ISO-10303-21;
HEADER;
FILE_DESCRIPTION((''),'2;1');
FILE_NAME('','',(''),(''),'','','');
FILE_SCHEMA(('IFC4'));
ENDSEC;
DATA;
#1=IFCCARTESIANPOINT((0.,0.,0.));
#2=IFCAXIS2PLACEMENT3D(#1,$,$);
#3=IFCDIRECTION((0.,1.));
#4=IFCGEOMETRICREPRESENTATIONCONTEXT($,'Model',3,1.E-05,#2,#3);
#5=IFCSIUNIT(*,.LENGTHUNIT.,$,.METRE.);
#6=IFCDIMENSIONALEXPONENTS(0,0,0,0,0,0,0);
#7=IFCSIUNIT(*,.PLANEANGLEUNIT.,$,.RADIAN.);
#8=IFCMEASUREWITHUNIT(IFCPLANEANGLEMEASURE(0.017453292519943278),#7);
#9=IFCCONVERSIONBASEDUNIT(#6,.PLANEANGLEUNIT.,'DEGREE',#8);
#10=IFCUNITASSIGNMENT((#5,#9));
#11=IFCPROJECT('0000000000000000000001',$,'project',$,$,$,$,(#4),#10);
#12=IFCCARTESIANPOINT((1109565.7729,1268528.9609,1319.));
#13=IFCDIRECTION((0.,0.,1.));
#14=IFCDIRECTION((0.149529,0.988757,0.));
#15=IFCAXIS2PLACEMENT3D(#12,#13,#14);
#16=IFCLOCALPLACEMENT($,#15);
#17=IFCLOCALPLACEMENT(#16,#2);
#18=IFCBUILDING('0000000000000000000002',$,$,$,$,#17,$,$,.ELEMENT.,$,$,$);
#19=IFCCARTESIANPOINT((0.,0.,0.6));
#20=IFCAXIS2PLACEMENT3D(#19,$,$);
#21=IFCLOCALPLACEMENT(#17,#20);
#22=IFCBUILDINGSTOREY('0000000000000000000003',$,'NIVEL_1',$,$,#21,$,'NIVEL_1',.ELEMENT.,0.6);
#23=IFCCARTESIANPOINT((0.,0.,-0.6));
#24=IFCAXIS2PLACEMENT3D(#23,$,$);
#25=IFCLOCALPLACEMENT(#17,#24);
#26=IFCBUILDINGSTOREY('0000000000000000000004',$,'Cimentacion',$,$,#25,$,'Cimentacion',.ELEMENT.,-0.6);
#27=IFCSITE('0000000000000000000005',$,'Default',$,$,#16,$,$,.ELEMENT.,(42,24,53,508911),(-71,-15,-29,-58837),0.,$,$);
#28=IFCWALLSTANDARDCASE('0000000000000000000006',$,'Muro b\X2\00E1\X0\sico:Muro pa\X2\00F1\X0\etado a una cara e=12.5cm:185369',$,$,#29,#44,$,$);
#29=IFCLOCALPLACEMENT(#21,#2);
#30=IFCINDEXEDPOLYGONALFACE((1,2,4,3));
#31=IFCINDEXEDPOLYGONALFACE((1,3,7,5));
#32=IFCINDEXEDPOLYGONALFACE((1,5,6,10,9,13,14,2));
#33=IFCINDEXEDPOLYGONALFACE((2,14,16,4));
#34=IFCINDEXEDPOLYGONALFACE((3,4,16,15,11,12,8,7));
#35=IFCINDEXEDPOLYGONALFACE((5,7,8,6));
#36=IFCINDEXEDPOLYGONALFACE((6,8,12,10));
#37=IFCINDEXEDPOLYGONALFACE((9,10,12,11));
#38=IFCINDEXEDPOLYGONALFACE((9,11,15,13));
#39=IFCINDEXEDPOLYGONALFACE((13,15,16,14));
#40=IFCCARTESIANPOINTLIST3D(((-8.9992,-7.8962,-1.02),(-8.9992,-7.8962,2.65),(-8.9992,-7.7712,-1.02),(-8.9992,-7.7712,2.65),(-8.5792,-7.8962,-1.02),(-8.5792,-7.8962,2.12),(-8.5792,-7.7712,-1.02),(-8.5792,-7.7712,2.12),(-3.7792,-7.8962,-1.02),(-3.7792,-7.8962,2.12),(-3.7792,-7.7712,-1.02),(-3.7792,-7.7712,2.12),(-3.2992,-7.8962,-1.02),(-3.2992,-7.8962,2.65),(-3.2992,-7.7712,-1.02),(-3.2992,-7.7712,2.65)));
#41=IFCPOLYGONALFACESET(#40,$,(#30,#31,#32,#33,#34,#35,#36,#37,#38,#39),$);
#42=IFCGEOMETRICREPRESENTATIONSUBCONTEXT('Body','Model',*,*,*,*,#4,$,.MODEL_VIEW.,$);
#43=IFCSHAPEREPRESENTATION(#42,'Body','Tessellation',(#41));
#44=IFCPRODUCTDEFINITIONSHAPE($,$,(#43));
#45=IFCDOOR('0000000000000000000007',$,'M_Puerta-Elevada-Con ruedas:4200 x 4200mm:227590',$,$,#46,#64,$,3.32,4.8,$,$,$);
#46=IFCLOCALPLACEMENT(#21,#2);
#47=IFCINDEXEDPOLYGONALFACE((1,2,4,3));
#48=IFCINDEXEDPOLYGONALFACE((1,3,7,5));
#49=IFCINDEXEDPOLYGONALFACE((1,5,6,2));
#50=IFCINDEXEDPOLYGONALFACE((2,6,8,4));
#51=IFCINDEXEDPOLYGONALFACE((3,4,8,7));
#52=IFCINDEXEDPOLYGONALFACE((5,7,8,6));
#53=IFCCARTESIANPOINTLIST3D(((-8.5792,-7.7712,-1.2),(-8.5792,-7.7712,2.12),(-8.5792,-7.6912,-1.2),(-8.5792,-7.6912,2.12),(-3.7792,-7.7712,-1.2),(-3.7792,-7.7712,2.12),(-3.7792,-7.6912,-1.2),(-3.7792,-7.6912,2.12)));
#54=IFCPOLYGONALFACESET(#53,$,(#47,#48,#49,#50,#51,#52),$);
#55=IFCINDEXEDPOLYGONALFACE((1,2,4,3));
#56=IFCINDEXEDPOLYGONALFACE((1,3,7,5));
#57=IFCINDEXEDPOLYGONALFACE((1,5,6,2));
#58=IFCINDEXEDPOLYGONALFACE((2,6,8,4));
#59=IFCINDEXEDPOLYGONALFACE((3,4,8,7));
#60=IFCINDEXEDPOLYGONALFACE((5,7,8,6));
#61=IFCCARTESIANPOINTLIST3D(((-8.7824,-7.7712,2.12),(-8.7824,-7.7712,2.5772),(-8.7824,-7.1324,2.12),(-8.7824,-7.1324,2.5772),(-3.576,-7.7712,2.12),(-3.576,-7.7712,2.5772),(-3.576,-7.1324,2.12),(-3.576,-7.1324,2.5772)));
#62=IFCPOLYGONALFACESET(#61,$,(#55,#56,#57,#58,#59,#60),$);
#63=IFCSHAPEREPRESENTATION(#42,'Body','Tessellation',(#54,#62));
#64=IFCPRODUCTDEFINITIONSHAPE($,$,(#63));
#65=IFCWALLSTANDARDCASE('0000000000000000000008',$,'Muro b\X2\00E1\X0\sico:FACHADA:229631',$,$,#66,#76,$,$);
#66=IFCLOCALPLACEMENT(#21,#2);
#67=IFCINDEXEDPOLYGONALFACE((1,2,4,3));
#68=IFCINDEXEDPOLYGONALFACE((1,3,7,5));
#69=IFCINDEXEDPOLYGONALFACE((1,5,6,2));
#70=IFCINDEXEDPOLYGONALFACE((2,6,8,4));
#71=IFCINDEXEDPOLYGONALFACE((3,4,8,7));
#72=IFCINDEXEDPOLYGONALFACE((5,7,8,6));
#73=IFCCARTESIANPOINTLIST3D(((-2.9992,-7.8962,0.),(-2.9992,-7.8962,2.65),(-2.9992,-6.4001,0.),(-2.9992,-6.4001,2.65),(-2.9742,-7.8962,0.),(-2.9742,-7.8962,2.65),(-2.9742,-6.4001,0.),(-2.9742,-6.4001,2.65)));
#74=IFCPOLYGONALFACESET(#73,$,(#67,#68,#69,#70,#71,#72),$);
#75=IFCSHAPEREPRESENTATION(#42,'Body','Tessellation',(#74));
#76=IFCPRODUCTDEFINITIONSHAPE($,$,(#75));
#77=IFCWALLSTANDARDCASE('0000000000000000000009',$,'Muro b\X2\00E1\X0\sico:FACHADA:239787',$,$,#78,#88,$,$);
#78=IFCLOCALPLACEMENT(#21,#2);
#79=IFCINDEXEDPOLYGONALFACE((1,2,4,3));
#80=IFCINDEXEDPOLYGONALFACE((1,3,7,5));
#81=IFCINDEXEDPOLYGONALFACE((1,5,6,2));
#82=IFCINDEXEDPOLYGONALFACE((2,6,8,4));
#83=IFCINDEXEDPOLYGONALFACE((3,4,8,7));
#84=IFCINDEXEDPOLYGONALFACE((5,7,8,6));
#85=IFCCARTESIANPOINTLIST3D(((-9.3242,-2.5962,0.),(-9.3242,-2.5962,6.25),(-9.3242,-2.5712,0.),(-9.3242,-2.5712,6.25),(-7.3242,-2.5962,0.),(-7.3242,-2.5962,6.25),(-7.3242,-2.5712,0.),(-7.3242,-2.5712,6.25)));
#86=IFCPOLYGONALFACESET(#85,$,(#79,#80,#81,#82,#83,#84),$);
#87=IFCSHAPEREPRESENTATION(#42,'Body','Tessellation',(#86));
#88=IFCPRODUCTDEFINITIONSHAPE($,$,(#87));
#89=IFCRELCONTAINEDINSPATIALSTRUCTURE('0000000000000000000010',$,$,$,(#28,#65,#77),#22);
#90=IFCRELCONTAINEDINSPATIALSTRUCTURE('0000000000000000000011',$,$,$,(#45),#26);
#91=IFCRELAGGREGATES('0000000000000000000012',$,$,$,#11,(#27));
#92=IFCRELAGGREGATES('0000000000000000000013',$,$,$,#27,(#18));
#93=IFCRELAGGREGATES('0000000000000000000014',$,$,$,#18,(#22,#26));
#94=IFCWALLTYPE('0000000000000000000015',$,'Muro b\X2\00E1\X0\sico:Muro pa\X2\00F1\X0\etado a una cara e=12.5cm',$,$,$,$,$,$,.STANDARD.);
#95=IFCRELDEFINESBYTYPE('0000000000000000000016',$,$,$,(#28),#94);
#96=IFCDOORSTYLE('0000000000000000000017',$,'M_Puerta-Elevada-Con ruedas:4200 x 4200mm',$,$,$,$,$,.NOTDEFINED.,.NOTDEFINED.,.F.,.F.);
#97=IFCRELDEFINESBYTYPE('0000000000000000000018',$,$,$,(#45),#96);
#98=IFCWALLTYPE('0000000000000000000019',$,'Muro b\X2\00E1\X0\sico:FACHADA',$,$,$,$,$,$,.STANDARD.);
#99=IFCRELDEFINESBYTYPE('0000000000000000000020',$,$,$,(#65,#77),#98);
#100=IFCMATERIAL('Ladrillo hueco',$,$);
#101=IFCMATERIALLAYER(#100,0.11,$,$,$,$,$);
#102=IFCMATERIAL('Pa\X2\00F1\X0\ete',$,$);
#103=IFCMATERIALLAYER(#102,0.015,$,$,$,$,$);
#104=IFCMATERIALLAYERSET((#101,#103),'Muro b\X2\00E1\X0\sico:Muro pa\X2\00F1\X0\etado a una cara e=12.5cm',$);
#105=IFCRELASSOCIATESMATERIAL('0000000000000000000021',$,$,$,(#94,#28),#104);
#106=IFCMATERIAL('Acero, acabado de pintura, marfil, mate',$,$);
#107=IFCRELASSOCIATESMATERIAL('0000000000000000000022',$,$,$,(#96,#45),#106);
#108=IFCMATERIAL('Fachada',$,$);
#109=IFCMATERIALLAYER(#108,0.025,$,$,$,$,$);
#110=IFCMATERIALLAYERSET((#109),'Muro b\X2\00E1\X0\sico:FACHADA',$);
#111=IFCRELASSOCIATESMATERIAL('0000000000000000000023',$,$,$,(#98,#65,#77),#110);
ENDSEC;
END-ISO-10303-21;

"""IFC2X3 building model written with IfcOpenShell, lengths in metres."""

from ifc_helpers import new_model, entity, si_unit, converted_unit, direction, frame, frame_2d, origin, place, context, subcontext, project, spatial, rectangle, extrude, source, transform, mapped, material, layer, layer_set, layer_usage, type_object, type_shapes, element, fill, save


model = new_model("IFC2X3")

# Units and contexts
model_context = context("Model", 3, precision=1e-05, world=origin(), true_north=direction((0.0, 1.0)))
body_context = subcontext(model_context, "Body", "Model", "MODEL_VIEW")
ifc_project = project(units=[si_unit("LENGTHUNIT", "METRE"), converted_unit("PLANEANGLEUNIT", "DEGREE", entity("IfcPlaneAngleMeasure", 0.017453292519943278), si_unit("PLANEANGLEUNIT", "RADIAN"), dimensions=[0, 0, 0, 0, 0, 0, 0])], contexts=[model_context])

# Site, building, storey
site_placement = place(None, frame((1109565.7729, 1268528.9609, 1319.0), z_axis=(0.0, 0.0, 1.0), x_axis=(0.149529, 0.988757, 0.0)))
site = spatial("IfcSite", under=ifc_project, at=site_placement, Name="Default", CompositionType="ELEMENT", RefLatitude=(42, 24, 53, 508911), RefLongitude=(-71, -15, -29, -58837), RefElevation=0.0)
building_placement = place(site_placement, origin())
building = spatial("IfcBuilding", under=site, at=building_placement, CompositionType="ELEMENT")
storey_1_placement = place(building_placement, frame((0.0, 0.0, 0.6)))
storey_1 = spatial("IfcBuildingStorey", under=building, at=storey_1_placement, Name="NIVEL_1", LongName="NIVEL_1", CompositionType="ELEMENT", Elevation=0.6)

# Shared definitions
ifc_material_1 = material(Name="Pañete")
ifc_material_2 = material(Name="Ladrillo hueco")
ifc_layer_1 = layer(ifc_material_2, 0.11)
ifc_layer_2 = layer(ifc_material_1, 0.015)
ifc_layer_set_1 = layer_set([ifc_layer_1, ifc_layer_2], Name="Muro básico:Muro pañetado a una cara e=12.5cm")
wall_type_1 = type_object("IfcWallType", Name="Muro básico:Muro pañetado a una cara e=12.5cm", PredefinedType="STANDARD", material=ifc_layer_set_1)

# Wall, opening
ifc_layer_usage_1 = layer_usage(ifc_layer_set_1, "AXIS2", "POSITIVE", -0.0625)
wall_1_placement = place(storey_1_placement, frame((-8.9992, -7.8337, -1.02)))
wall_1 = element("IfcWallStandardCase", 1, at=wall_1_placement, inside=storey_1, type_object=wall_type_1, material=ifc_layer_usage_1, Name="Muro básico:Muro pañetado a una cara e=12.5cm:185369", context=body_context, shape_type="SweptSolid", body=[
    extrude(rectangle(XDim=5.7, YDim=0.125, at=frame_2d((2.85, 0.0), x_axis=(1.0, 0.0))), origin(), (0.0, 0.0, 1.0), 3.67),
])
opening_1_placement = place(wall_1_placement, frame((0.42, -0.0625, -0.18)))
opening_1 = element("IfcOpeningElement", 2, at=opening_1_placement, cuts=wall_1, ObjectType="Opening", context=body_context, shape_type="SweptSolid", body=[
    extrude(rectangle(XDim=3.32, YDim=4.8, at=frame_2d((1.66, 2.4), x_axis=(1.0, 0.0))), frame((0.0, 0.0, 0.0), z_axis=(0.0, 1.0, 0.0), x_axis=(0.0, 0.0, 1.0)), (0.0, 0.0, 1.0), 0.125),
])

# Shared definitions
storey_2_placement = place(building_placement, frame((0.0, 0.0, -0.6)))
storey_2 = spatial("IfcBuildingStorey", under=building, at=storey_2_placement, Name="Cimentacion", LongName="Cimentacion", CompositionType="ELEMENT", Elevation=-0.6)

# Door
ifc_material_3 = material(Name="Acero, acabado de pintura, marfil, mate")
door_style = type_object("IfcDoorStyle", Name="M_Puerta-Elevada-Con ruedas:4200 x 4200mm", ConstructionType="NOTDEFINED", OperationType="NOTDEFINED", ParameterTakesPrecedence=False, Sizeable=False, material=ifc_material_3)
shared_shape_1 = source(origin(), body_context, "Body", "SweptSolid", [
    extrude(rectangle(XDim=4.8, YDim=0.08, at=frame_2d((0.0, 0.0), x_axis=(1.0, 0.0))), frame((2.4, -0.04, 0.0), z_axis=(0.0, 0.0, 1.0), x_axis=(-1.0, 0.0, 0.0)), (0.0, 0.0, 1.0), 3.32),
    extrude(rectangle(XDim=0.6388, YDim=5.2064, at=frame_2d((0.0, 0.0), x_axis=(1.0, 0.0))), frame((2.4, -0.3194, 3.32), z_axis=(0.0, 0.0, 1.0), x_axis=(0.0, 1.0, 0.0)), (0.0, 0.0, 1.0), 0.4572),
])
type_shapes(door_style, [shared_shape_1])
door_placement = place(opening_1_placement, frame((4.8, 0.125, 0.0), z_axis=(0.0, 0.0, 1.0), x_axis=(-1.0, 0.0, 0.0)))
door = element("IfcDoor", 3, at=door_placement, inside=storey_2, type_object=door_style, material=ifc_material_3, Name="M_Puerta-Elevada-Con ruedas:4200 x 4200mm:227590", OverallHeight=3.32, OverallWidth=4.8, context=body_context, shape_type="MappedRepresentation", body=[
    mapped(shared_shape_1, transform((0.0, 0.0, 0.0), scale=1.0)),
])
fill(opening_1, door)

# Shared definitions
ifc_material_4 = material(Name="Fachada")
ifc_layer_3 = layer(ifc_material_4, 0.025)
ifc_layer_set_2 = layer_set([ifc_layer_3], Name="Muro básico:FACHADA")
wall_type_2 = type_object("IfcWallType", Name="Muro básico:FACHADA", PredefinedType="STANDARD", material=ifc_layer_set_2)

# Walls
ifc_layer_usage_2 = layer_usage(ifc_layer_set_2, "AXIS2", "POSITIVE", -0.0125)
wall_2_placement = place(storey_1_placement, frame((-2.9867, -7.8962, 0.0), z_axis=(0.0, 0.0, 1.0), x_axis=(0.0, 1.0, 0.0)))
element("IfcWallStandardCase", 4, at=wall_2_placement, inside=storey_1, type_object=wall_type_2, material=ifc_layer_usage_2, Name="Muro básico:FACHADA:229631", context=body_context, shape_type="SweptSolid", body=[
    extrude(rectangle(XDim=1.4961, YDim=0.025, at=frame_2d((0.748, 0.0), x_axis=(-1.0, 0.0))), origin(), (0.0, 0.0, 1.0), 2.65),
])
ifc_layer_usage_3 = layer_usage(ifc_layer_set_2, "AXIS2", "POSITIVE", -0.0125)
wall_3_placement = place(storey_1_placement, frame((-7.3242, -2.5837, 0.0), z_axis=(0.0, 0.0, 1.0), x_axis=(-1.0, 0.0, 0.0)))
element("IfcWallStandardCase", 5, at=wall_3_placement, inside=storey_1, type_object=wall_type_2, material=ifc_layer_usage_3, Name="Muro básico:FACHADA:239787", context=body_context, shape_type="SweptSolid", body=[
    extrude(rectangle(XDim=2.0, YDim=0.025, at=frame_2d((1.0, 0.0), x_axis=(-1.0, 0.0))), origin(), (0.0, 0.0, 1.0), 6.25),
])

save(model, "model.ifc")
